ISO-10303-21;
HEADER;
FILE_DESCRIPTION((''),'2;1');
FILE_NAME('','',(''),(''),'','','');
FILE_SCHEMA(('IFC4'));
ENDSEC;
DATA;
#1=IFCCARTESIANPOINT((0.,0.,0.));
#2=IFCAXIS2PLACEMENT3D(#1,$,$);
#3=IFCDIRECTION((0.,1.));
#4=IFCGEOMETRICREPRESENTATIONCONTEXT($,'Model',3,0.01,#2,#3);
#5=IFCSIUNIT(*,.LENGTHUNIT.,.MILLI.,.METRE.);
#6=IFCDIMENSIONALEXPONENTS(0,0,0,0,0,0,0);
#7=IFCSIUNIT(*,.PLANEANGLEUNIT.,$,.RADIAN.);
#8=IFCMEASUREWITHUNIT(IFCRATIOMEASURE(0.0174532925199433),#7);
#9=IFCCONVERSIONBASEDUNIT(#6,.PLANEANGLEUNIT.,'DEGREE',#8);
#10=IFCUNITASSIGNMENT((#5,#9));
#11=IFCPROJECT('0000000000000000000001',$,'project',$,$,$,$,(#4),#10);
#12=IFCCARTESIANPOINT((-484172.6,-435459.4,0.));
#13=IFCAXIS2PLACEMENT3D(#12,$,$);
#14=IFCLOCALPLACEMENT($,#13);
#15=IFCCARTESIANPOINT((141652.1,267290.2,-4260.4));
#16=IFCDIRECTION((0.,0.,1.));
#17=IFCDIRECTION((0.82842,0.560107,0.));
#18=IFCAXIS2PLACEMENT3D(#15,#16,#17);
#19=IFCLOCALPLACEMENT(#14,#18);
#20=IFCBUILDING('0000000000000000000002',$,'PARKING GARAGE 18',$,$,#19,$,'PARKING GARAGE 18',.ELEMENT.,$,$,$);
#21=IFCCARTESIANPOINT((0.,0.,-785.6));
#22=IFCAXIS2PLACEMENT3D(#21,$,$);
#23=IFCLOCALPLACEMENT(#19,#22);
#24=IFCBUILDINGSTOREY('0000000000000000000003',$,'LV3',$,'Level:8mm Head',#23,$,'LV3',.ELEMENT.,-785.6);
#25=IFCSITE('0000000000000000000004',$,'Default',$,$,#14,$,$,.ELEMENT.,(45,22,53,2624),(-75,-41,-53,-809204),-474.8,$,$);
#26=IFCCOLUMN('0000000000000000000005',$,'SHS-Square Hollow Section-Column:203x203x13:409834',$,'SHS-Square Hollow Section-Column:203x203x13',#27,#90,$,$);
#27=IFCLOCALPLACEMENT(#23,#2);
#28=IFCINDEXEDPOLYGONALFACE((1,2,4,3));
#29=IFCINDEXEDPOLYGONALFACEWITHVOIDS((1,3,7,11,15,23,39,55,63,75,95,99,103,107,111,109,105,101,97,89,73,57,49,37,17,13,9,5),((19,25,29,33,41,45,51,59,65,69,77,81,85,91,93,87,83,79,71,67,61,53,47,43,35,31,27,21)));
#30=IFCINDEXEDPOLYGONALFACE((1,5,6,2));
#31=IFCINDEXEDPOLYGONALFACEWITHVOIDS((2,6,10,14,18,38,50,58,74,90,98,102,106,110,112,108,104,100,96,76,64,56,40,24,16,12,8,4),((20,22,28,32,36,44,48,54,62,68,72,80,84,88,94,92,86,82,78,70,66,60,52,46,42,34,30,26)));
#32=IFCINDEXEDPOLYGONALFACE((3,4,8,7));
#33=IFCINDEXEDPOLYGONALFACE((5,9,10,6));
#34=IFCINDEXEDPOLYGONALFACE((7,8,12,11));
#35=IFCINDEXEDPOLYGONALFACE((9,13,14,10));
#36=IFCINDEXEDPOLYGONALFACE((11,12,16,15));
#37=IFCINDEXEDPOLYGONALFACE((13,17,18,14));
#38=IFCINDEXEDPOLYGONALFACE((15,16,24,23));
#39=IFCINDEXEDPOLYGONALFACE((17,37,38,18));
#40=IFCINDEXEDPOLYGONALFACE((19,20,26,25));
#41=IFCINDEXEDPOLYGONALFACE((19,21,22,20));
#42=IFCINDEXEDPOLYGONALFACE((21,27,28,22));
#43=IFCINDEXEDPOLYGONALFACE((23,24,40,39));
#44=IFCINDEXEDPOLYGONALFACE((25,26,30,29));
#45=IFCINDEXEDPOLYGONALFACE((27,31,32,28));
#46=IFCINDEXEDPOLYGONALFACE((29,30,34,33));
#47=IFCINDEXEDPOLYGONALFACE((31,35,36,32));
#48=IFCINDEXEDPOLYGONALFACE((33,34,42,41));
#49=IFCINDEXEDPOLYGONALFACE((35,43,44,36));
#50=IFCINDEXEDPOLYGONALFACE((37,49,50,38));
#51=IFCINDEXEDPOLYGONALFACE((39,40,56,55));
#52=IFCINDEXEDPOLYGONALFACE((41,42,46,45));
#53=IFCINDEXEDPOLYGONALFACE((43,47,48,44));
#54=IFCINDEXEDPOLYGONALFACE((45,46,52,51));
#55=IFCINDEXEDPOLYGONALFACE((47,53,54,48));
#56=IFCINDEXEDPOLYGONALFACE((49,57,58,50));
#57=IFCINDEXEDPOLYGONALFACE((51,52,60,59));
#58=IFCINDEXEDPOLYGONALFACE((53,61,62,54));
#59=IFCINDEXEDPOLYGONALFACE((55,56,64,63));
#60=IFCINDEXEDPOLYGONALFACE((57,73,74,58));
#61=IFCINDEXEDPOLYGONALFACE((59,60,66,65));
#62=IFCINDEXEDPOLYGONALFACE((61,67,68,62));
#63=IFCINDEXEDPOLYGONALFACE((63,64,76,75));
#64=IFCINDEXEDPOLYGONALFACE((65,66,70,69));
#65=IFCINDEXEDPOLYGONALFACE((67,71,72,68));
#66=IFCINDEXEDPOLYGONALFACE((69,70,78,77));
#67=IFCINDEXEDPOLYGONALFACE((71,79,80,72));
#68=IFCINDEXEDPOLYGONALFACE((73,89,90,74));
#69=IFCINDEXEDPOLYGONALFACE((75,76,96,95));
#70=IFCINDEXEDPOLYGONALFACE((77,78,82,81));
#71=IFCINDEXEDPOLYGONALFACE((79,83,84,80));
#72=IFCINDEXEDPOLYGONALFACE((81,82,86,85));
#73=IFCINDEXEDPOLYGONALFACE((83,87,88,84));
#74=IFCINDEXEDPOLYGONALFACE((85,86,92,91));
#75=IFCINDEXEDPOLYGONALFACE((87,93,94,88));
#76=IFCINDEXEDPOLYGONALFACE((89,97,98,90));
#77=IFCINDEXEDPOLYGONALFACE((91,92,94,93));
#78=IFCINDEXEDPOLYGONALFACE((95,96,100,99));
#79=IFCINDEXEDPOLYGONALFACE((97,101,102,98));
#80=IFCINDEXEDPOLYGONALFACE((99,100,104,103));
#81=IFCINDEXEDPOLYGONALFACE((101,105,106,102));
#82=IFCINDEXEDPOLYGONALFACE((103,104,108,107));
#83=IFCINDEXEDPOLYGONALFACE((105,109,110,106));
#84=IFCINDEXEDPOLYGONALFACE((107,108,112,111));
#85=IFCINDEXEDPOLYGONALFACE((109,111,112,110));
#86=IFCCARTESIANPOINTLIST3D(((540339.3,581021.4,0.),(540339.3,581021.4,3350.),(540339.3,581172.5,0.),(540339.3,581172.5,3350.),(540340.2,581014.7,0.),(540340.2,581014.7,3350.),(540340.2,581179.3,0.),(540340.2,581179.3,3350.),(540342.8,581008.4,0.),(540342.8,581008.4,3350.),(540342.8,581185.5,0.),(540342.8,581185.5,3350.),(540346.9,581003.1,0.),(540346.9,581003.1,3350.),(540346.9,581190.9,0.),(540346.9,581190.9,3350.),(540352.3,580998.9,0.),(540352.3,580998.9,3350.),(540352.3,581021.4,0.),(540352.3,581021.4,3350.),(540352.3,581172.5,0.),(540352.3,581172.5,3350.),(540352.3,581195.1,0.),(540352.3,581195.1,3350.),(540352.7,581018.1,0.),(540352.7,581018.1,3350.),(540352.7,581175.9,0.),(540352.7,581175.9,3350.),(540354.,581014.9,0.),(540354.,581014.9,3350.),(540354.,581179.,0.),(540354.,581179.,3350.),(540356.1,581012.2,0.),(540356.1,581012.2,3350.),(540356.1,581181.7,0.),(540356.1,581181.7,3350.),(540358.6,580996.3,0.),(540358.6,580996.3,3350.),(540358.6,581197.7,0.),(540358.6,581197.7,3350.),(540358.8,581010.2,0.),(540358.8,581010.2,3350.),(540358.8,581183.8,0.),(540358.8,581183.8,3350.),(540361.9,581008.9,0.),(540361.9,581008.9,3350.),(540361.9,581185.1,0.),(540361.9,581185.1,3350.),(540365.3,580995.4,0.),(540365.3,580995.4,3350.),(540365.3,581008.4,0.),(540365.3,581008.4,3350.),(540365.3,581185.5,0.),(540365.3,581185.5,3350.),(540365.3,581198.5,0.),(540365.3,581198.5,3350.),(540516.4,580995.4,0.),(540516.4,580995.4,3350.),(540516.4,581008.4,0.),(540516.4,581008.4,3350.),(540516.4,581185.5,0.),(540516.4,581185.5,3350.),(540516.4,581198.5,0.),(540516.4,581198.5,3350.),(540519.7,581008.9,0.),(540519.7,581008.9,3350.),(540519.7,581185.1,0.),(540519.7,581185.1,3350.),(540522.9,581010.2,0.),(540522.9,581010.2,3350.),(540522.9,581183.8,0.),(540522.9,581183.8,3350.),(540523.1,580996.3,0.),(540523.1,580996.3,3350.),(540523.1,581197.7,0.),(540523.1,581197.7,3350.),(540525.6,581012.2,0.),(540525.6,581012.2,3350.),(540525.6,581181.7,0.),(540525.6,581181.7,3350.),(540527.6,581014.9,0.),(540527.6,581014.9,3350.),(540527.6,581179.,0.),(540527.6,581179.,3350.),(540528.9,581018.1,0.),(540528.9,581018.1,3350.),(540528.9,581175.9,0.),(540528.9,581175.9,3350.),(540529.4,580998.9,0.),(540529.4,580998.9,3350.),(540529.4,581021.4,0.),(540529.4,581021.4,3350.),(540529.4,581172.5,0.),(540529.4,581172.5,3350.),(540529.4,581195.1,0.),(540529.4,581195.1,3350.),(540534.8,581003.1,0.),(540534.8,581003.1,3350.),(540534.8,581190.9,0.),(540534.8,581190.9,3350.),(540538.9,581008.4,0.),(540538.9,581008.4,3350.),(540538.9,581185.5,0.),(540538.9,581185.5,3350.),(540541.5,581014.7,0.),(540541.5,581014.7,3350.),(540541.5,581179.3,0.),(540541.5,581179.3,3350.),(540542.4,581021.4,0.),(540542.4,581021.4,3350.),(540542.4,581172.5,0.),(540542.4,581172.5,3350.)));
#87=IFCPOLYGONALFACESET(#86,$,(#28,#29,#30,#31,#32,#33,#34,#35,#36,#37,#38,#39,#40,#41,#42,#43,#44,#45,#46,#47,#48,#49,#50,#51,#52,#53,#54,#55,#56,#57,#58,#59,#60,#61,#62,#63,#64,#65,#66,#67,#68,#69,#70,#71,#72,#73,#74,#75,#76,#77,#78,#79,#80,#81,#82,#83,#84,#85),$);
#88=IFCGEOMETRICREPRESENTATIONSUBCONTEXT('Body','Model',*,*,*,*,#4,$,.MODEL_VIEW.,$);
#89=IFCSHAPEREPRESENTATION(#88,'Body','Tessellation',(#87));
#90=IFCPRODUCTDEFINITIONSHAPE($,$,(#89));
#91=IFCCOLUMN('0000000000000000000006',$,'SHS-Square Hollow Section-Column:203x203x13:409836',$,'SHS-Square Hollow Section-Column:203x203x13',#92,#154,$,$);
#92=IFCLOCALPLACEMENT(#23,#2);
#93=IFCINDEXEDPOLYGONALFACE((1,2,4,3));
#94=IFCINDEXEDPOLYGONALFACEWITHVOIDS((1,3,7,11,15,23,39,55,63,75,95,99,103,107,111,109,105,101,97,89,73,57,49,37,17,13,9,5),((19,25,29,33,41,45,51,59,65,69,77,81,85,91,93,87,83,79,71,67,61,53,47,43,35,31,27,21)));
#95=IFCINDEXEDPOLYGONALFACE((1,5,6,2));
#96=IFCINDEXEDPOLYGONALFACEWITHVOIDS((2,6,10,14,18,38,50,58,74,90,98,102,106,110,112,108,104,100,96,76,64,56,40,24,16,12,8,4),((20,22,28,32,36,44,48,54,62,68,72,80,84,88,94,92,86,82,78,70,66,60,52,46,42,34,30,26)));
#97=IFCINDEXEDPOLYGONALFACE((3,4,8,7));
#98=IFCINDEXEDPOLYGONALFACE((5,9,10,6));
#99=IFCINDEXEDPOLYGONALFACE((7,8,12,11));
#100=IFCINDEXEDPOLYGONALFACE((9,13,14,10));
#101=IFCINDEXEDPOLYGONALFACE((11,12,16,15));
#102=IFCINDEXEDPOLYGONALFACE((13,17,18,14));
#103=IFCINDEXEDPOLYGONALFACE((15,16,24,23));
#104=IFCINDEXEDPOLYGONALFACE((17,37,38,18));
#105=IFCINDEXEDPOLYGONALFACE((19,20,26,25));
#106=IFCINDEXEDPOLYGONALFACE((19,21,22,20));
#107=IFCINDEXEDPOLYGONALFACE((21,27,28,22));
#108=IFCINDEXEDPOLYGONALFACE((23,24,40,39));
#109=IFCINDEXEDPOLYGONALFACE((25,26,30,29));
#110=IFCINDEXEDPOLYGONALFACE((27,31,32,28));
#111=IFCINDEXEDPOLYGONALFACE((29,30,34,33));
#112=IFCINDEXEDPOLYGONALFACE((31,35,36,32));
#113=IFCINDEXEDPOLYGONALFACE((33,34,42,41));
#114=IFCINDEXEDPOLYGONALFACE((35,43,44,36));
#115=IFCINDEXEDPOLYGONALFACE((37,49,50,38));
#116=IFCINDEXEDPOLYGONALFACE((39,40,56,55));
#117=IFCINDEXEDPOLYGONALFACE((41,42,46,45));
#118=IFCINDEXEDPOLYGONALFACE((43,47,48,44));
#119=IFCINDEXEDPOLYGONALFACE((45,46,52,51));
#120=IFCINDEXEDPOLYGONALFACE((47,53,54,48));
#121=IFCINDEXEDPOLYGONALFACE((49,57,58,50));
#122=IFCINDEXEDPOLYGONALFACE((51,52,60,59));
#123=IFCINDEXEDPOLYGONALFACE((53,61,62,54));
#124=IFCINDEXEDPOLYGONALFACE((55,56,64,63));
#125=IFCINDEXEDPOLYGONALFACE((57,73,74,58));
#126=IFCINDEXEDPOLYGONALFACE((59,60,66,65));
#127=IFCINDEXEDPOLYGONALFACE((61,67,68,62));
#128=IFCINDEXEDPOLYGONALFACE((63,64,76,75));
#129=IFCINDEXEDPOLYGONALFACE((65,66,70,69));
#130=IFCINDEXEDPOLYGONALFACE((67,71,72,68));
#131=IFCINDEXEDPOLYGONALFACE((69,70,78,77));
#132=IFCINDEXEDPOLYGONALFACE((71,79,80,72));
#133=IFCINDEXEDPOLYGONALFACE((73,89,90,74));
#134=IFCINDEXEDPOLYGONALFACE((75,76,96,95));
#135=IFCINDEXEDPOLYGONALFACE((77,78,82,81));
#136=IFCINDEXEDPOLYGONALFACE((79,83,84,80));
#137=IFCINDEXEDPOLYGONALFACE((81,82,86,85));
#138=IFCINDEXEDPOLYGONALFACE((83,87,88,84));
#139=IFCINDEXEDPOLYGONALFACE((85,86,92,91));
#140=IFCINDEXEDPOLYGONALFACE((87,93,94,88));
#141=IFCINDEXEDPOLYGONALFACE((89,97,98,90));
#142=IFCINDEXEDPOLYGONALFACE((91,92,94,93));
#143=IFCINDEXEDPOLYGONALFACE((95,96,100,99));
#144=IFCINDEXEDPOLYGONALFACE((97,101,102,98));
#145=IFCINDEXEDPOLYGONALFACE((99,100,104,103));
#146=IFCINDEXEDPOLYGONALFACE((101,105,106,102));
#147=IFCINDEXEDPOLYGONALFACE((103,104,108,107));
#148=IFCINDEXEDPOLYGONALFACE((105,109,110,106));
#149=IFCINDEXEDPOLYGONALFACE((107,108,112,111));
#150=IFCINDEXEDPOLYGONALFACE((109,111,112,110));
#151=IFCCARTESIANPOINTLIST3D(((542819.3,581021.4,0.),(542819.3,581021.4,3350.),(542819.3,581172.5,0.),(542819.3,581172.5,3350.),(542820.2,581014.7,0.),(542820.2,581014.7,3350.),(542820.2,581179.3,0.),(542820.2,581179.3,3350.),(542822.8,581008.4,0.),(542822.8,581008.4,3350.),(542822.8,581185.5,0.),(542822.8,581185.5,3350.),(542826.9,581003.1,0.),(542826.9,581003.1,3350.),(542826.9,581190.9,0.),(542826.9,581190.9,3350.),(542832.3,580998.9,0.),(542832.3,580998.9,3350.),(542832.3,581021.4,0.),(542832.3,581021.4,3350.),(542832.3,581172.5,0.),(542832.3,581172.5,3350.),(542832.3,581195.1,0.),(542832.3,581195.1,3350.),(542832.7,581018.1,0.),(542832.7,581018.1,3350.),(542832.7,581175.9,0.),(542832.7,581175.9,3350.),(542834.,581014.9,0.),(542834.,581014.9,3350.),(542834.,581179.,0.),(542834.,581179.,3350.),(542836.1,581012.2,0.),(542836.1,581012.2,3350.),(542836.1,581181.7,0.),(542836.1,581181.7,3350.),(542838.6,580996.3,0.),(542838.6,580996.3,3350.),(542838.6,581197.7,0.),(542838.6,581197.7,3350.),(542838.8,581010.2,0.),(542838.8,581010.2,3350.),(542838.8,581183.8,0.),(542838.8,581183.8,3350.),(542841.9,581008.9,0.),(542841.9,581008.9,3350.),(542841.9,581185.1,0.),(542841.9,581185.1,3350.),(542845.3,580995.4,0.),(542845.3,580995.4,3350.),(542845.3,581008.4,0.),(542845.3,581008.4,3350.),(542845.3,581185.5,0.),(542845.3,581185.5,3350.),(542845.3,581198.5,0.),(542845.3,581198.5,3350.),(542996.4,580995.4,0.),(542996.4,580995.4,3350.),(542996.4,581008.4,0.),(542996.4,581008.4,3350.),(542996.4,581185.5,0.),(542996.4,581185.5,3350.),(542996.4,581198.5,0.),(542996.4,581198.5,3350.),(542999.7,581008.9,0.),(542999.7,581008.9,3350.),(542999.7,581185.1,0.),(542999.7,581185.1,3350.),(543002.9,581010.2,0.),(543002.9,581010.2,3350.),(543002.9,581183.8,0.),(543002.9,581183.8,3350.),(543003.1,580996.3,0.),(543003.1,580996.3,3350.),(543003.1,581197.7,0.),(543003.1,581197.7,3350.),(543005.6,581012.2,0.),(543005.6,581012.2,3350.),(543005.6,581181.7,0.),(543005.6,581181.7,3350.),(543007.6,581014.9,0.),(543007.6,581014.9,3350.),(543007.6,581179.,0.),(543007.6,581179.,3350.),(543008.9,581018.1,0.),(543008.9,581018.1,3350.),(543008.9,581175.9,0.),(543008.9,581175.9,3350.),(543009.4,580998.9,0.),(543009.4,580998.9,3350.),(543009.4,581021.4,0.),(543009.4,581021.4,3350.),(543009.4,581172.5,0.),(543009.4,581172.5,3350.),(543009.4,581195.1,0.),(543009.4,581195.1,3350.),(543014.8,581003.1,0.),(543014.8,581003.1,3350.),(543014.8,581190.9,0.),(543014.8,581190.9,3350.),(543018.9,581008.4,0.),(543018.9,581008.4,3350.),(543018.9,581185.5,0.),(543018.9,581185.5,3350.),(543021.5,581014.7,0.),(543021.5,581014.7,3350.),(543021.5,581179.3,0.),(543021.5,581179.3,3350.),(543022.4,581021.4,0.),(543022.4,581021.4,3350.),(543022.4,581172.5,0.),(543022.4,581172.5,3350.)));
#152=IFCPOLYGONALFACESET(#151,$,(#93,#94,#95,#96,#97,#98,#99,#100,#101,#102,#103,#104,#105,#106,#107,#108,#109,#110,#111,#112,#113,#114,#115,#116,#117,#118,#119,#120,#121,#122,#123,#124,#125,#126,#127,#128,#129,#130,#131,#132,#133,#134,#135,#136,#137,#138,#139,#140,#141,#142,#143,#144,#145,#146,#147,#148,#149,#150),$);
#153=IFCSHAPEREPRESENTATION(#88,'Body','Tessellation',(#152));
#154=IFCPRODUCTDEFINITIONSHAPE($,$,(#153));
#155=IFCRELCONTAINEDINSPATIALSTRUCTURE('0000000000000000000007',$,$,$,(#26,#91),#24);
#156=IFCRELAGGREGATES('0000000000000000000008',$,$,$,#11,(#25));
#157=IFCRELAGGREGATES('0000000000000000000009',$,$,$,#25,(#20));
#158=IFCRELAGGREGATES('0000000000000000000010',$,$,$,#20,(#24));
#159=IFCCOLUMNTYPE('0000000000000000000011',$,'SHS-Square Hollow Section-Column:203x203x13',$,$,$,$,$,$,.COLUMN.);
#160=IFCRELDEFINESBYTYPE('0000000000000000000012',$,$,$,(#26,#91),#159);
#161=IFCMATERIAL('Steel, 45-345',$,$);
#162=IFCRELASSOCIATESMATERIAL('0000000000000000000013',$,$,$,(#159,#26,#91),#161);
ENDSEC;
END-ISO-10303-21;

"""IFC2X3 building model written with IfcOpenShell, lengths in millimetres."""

from ifc_helpers import new_model, entity, si_unit, converted_unit, direction, frame, frame_2d, origin, place, context, subcontext, project, spatial, polyline, circle_curve, parameter, trimmed, segment, composite_curve, outline, extrude, source, transform, mapped, material, type_object, type_shapes, element, save


model = new_model("IFC2X3")

# Units and contexts
model_context = context("Model", 3, precision=0.01, world=origin(), true_north=direction((0.0, 1.0)))
body_context = subcontext(model_context, "Body", "Model", "MODEL_VIEW")
ifc_project = project(units=[si_unit("LENGTHUNIT", "METRE", prefix="MILLI"), converted_unit("PLANEANGLEUNIT", "DEGREE", entity("IfcRatioMeasure", 0.0174532925199433), si_unit("PLANEANGLEUNIT", "RADIAN"), dimensions=[0, 0, 0, 0, 0, 0, 0])], contexts=[model_context])

# Site, building, storey
site_placement = place(None, frame((-484172.6, -435459.4, 0.0)))
site = spatial("IfcSite", under=ifc_project, at=site_placement, Name="Default", CompositionType="ELEMENT", RefLatitude=(45, 22, 53, 2624), RefLongitude=(-75, -41, -53, -809204), RefElevation=-474.8)
building_placement = place(site_placement, frame((141652.1, 267290.2, -4260.4), z_axis=(0.0, 0.0, 1.0), x_axis=(0.82842, 0.560107, 0.0)))
building = spatial("IfcBuilding", under=site, at=building_placement, Name="PARKING GARAGE 18", LongName="PARKING GARAGE 18", CompositionType="ELEMENT")
storey_placement = place(building_placement, frame((0.0, 0.0, -785.6)))
storey = spatial("IfcBuildingStorey", under=building, at=storey_placement, Name="LV3", ObjectType="Level:8mm Head", LongName="LV3", CompositionType="ELEMENT", Elevation=-785.6)

# Columns
ifc_material_1 = material(Name="Steel, 45-345")
column_type = type_object("IfcColumnType", Name="SHS-Square Hollow Section-Column:203x203x13", PredefinedType="COLUMN", material=ifc_material_1)
shared_shape_1 = source(origin(), body_context, "Body", "SweptSolid", [
    extrude(outline(composite_curve([segment(polyline([(-75.6, -101.5), (75.6, -101.5)]), True, "CONTINUOUS"), segment(trimmed(circle_curve(frame_2d((75.6, -75.6), x_axis=(-1.0, 0.0)), 26.0), [parameter(90.0)], [parameter(180.0)], True, "PARAMETER"), True, "CONTINUOUS"), segment(polyline([(101.5, -75.6), (101.5, 75.6)]), True, "CONTINUOUS"), segment(trimmed(circle_curve(frame_2d((75.5, 75.6), x_axis=(-1.0, 0.0)), 26.0), [parameter(180.0)], [parameter(270.0)], True, "PARAMETER"), True, "CONTINUOUS"), segment(polyline([(75.5, 101.6), (-75.5, 101.6)]), True, "CONTINUOUS"), segment(trimmed(circle_curve(frame_2d((-75.5, 75.5), x_axis=(-1.0, 0.0)), 26.0), [parameter(270.0)], [parameter(360.0)], True, "PARAMETER"), True, "CONTINUOUS"), segment(polyline([(-101.5, 75.5), (-101.5, -75.6)]), True, "CONTINUOUS"), segment(trimmed(circle_curve(frame_2d((-75.6, -75.6), x_axis=(-1.0, 0.0)), 26.0), [parameter(360.0)], [parameter(90.0)], True, "PARAMETER"), True, "CONTINUOUS")], self_intersect=False), holes=[composite_curve([segment(trimmed(circle_curve(frame_2d((-75.6, -75.6), x_axis=(-1.0, 0.0)), 13.0), [parameter(0.0)], [parameter(90.0)], True, "PARAMETER"), False, "CONTINUOUS"), segment(polyline([(-88.5, -75.6), (-88.5, 75.6)]), True, "CONTINUOUS"), segment(trimmed(circle_curve(frame_2d((-75.6, 75.6), x_axis=(-1.0, 0.0)), 13.0), [parameter(270.0)], [parameter(0.0)], True, "PARAMETER"), False, "CONTINUOUS"), segment(polyline([(-75.6, 88.6), (75.5, 88.6)]), True, "CONTINUOUS"), segment(trimmed(circle_curve(frame_2d((75.5, 75.5), x_axis=(-1.0, 0.0)), 13.0), [parameter(180.0)], [parameter(270.0)], True, "PARAMETER"), False, "CONTINUOUS"), segment(polyline([(88.6, 75.5), (88.6, -75.5)]), True, "CONTINUOUS"), segment(trimmed(circle_curve(frame_2d((75.6, -75.5), x_axis=(-1.0, 0.0)), 13.0), [parameter(90.0)], [parameter(180.0)], True, "PARAMETER"), False, "CONTINUOUS"), segment(polyline([(75.6, -88.5), (-75.6, -88.5)]), True, "CONTINUOUS")], self_intersect=False)]), frame((0.0, 0.0, -785.6), z_axis=(0.0, 0.0, 1.0), x_axis=(-1.0, 0.0, 0.0)), (0.0, 0.0, 1.0), 3350.0),
])
type_shapes(column_type, [shared_shape_1])
for number, where, name in (
    (1, (540440.8, 581097.0, 785.6), "SHS-Square Hollow Section-Column:203x203x13:409834"),
    (2, (542920.8, 581097.0, 785.6), "SHS-Square Hollow Section-Column:203x203x13:409836"),
):
    element("IfcColumn", number, at=place(storey_placement, frame(where)), inside=storey, type_object=column_type, material=ifc_material_1, Name=name, ObjectType="SHS-Square Hollow Section-Column:203x203x13", context=body_context, shape_type="MappedRepresentation", body=[
        mapped(shared_shape_1, transform((0.0, 0.0, 0.0), scale=1.0)),
    ])

save(model, "model.ifc")
